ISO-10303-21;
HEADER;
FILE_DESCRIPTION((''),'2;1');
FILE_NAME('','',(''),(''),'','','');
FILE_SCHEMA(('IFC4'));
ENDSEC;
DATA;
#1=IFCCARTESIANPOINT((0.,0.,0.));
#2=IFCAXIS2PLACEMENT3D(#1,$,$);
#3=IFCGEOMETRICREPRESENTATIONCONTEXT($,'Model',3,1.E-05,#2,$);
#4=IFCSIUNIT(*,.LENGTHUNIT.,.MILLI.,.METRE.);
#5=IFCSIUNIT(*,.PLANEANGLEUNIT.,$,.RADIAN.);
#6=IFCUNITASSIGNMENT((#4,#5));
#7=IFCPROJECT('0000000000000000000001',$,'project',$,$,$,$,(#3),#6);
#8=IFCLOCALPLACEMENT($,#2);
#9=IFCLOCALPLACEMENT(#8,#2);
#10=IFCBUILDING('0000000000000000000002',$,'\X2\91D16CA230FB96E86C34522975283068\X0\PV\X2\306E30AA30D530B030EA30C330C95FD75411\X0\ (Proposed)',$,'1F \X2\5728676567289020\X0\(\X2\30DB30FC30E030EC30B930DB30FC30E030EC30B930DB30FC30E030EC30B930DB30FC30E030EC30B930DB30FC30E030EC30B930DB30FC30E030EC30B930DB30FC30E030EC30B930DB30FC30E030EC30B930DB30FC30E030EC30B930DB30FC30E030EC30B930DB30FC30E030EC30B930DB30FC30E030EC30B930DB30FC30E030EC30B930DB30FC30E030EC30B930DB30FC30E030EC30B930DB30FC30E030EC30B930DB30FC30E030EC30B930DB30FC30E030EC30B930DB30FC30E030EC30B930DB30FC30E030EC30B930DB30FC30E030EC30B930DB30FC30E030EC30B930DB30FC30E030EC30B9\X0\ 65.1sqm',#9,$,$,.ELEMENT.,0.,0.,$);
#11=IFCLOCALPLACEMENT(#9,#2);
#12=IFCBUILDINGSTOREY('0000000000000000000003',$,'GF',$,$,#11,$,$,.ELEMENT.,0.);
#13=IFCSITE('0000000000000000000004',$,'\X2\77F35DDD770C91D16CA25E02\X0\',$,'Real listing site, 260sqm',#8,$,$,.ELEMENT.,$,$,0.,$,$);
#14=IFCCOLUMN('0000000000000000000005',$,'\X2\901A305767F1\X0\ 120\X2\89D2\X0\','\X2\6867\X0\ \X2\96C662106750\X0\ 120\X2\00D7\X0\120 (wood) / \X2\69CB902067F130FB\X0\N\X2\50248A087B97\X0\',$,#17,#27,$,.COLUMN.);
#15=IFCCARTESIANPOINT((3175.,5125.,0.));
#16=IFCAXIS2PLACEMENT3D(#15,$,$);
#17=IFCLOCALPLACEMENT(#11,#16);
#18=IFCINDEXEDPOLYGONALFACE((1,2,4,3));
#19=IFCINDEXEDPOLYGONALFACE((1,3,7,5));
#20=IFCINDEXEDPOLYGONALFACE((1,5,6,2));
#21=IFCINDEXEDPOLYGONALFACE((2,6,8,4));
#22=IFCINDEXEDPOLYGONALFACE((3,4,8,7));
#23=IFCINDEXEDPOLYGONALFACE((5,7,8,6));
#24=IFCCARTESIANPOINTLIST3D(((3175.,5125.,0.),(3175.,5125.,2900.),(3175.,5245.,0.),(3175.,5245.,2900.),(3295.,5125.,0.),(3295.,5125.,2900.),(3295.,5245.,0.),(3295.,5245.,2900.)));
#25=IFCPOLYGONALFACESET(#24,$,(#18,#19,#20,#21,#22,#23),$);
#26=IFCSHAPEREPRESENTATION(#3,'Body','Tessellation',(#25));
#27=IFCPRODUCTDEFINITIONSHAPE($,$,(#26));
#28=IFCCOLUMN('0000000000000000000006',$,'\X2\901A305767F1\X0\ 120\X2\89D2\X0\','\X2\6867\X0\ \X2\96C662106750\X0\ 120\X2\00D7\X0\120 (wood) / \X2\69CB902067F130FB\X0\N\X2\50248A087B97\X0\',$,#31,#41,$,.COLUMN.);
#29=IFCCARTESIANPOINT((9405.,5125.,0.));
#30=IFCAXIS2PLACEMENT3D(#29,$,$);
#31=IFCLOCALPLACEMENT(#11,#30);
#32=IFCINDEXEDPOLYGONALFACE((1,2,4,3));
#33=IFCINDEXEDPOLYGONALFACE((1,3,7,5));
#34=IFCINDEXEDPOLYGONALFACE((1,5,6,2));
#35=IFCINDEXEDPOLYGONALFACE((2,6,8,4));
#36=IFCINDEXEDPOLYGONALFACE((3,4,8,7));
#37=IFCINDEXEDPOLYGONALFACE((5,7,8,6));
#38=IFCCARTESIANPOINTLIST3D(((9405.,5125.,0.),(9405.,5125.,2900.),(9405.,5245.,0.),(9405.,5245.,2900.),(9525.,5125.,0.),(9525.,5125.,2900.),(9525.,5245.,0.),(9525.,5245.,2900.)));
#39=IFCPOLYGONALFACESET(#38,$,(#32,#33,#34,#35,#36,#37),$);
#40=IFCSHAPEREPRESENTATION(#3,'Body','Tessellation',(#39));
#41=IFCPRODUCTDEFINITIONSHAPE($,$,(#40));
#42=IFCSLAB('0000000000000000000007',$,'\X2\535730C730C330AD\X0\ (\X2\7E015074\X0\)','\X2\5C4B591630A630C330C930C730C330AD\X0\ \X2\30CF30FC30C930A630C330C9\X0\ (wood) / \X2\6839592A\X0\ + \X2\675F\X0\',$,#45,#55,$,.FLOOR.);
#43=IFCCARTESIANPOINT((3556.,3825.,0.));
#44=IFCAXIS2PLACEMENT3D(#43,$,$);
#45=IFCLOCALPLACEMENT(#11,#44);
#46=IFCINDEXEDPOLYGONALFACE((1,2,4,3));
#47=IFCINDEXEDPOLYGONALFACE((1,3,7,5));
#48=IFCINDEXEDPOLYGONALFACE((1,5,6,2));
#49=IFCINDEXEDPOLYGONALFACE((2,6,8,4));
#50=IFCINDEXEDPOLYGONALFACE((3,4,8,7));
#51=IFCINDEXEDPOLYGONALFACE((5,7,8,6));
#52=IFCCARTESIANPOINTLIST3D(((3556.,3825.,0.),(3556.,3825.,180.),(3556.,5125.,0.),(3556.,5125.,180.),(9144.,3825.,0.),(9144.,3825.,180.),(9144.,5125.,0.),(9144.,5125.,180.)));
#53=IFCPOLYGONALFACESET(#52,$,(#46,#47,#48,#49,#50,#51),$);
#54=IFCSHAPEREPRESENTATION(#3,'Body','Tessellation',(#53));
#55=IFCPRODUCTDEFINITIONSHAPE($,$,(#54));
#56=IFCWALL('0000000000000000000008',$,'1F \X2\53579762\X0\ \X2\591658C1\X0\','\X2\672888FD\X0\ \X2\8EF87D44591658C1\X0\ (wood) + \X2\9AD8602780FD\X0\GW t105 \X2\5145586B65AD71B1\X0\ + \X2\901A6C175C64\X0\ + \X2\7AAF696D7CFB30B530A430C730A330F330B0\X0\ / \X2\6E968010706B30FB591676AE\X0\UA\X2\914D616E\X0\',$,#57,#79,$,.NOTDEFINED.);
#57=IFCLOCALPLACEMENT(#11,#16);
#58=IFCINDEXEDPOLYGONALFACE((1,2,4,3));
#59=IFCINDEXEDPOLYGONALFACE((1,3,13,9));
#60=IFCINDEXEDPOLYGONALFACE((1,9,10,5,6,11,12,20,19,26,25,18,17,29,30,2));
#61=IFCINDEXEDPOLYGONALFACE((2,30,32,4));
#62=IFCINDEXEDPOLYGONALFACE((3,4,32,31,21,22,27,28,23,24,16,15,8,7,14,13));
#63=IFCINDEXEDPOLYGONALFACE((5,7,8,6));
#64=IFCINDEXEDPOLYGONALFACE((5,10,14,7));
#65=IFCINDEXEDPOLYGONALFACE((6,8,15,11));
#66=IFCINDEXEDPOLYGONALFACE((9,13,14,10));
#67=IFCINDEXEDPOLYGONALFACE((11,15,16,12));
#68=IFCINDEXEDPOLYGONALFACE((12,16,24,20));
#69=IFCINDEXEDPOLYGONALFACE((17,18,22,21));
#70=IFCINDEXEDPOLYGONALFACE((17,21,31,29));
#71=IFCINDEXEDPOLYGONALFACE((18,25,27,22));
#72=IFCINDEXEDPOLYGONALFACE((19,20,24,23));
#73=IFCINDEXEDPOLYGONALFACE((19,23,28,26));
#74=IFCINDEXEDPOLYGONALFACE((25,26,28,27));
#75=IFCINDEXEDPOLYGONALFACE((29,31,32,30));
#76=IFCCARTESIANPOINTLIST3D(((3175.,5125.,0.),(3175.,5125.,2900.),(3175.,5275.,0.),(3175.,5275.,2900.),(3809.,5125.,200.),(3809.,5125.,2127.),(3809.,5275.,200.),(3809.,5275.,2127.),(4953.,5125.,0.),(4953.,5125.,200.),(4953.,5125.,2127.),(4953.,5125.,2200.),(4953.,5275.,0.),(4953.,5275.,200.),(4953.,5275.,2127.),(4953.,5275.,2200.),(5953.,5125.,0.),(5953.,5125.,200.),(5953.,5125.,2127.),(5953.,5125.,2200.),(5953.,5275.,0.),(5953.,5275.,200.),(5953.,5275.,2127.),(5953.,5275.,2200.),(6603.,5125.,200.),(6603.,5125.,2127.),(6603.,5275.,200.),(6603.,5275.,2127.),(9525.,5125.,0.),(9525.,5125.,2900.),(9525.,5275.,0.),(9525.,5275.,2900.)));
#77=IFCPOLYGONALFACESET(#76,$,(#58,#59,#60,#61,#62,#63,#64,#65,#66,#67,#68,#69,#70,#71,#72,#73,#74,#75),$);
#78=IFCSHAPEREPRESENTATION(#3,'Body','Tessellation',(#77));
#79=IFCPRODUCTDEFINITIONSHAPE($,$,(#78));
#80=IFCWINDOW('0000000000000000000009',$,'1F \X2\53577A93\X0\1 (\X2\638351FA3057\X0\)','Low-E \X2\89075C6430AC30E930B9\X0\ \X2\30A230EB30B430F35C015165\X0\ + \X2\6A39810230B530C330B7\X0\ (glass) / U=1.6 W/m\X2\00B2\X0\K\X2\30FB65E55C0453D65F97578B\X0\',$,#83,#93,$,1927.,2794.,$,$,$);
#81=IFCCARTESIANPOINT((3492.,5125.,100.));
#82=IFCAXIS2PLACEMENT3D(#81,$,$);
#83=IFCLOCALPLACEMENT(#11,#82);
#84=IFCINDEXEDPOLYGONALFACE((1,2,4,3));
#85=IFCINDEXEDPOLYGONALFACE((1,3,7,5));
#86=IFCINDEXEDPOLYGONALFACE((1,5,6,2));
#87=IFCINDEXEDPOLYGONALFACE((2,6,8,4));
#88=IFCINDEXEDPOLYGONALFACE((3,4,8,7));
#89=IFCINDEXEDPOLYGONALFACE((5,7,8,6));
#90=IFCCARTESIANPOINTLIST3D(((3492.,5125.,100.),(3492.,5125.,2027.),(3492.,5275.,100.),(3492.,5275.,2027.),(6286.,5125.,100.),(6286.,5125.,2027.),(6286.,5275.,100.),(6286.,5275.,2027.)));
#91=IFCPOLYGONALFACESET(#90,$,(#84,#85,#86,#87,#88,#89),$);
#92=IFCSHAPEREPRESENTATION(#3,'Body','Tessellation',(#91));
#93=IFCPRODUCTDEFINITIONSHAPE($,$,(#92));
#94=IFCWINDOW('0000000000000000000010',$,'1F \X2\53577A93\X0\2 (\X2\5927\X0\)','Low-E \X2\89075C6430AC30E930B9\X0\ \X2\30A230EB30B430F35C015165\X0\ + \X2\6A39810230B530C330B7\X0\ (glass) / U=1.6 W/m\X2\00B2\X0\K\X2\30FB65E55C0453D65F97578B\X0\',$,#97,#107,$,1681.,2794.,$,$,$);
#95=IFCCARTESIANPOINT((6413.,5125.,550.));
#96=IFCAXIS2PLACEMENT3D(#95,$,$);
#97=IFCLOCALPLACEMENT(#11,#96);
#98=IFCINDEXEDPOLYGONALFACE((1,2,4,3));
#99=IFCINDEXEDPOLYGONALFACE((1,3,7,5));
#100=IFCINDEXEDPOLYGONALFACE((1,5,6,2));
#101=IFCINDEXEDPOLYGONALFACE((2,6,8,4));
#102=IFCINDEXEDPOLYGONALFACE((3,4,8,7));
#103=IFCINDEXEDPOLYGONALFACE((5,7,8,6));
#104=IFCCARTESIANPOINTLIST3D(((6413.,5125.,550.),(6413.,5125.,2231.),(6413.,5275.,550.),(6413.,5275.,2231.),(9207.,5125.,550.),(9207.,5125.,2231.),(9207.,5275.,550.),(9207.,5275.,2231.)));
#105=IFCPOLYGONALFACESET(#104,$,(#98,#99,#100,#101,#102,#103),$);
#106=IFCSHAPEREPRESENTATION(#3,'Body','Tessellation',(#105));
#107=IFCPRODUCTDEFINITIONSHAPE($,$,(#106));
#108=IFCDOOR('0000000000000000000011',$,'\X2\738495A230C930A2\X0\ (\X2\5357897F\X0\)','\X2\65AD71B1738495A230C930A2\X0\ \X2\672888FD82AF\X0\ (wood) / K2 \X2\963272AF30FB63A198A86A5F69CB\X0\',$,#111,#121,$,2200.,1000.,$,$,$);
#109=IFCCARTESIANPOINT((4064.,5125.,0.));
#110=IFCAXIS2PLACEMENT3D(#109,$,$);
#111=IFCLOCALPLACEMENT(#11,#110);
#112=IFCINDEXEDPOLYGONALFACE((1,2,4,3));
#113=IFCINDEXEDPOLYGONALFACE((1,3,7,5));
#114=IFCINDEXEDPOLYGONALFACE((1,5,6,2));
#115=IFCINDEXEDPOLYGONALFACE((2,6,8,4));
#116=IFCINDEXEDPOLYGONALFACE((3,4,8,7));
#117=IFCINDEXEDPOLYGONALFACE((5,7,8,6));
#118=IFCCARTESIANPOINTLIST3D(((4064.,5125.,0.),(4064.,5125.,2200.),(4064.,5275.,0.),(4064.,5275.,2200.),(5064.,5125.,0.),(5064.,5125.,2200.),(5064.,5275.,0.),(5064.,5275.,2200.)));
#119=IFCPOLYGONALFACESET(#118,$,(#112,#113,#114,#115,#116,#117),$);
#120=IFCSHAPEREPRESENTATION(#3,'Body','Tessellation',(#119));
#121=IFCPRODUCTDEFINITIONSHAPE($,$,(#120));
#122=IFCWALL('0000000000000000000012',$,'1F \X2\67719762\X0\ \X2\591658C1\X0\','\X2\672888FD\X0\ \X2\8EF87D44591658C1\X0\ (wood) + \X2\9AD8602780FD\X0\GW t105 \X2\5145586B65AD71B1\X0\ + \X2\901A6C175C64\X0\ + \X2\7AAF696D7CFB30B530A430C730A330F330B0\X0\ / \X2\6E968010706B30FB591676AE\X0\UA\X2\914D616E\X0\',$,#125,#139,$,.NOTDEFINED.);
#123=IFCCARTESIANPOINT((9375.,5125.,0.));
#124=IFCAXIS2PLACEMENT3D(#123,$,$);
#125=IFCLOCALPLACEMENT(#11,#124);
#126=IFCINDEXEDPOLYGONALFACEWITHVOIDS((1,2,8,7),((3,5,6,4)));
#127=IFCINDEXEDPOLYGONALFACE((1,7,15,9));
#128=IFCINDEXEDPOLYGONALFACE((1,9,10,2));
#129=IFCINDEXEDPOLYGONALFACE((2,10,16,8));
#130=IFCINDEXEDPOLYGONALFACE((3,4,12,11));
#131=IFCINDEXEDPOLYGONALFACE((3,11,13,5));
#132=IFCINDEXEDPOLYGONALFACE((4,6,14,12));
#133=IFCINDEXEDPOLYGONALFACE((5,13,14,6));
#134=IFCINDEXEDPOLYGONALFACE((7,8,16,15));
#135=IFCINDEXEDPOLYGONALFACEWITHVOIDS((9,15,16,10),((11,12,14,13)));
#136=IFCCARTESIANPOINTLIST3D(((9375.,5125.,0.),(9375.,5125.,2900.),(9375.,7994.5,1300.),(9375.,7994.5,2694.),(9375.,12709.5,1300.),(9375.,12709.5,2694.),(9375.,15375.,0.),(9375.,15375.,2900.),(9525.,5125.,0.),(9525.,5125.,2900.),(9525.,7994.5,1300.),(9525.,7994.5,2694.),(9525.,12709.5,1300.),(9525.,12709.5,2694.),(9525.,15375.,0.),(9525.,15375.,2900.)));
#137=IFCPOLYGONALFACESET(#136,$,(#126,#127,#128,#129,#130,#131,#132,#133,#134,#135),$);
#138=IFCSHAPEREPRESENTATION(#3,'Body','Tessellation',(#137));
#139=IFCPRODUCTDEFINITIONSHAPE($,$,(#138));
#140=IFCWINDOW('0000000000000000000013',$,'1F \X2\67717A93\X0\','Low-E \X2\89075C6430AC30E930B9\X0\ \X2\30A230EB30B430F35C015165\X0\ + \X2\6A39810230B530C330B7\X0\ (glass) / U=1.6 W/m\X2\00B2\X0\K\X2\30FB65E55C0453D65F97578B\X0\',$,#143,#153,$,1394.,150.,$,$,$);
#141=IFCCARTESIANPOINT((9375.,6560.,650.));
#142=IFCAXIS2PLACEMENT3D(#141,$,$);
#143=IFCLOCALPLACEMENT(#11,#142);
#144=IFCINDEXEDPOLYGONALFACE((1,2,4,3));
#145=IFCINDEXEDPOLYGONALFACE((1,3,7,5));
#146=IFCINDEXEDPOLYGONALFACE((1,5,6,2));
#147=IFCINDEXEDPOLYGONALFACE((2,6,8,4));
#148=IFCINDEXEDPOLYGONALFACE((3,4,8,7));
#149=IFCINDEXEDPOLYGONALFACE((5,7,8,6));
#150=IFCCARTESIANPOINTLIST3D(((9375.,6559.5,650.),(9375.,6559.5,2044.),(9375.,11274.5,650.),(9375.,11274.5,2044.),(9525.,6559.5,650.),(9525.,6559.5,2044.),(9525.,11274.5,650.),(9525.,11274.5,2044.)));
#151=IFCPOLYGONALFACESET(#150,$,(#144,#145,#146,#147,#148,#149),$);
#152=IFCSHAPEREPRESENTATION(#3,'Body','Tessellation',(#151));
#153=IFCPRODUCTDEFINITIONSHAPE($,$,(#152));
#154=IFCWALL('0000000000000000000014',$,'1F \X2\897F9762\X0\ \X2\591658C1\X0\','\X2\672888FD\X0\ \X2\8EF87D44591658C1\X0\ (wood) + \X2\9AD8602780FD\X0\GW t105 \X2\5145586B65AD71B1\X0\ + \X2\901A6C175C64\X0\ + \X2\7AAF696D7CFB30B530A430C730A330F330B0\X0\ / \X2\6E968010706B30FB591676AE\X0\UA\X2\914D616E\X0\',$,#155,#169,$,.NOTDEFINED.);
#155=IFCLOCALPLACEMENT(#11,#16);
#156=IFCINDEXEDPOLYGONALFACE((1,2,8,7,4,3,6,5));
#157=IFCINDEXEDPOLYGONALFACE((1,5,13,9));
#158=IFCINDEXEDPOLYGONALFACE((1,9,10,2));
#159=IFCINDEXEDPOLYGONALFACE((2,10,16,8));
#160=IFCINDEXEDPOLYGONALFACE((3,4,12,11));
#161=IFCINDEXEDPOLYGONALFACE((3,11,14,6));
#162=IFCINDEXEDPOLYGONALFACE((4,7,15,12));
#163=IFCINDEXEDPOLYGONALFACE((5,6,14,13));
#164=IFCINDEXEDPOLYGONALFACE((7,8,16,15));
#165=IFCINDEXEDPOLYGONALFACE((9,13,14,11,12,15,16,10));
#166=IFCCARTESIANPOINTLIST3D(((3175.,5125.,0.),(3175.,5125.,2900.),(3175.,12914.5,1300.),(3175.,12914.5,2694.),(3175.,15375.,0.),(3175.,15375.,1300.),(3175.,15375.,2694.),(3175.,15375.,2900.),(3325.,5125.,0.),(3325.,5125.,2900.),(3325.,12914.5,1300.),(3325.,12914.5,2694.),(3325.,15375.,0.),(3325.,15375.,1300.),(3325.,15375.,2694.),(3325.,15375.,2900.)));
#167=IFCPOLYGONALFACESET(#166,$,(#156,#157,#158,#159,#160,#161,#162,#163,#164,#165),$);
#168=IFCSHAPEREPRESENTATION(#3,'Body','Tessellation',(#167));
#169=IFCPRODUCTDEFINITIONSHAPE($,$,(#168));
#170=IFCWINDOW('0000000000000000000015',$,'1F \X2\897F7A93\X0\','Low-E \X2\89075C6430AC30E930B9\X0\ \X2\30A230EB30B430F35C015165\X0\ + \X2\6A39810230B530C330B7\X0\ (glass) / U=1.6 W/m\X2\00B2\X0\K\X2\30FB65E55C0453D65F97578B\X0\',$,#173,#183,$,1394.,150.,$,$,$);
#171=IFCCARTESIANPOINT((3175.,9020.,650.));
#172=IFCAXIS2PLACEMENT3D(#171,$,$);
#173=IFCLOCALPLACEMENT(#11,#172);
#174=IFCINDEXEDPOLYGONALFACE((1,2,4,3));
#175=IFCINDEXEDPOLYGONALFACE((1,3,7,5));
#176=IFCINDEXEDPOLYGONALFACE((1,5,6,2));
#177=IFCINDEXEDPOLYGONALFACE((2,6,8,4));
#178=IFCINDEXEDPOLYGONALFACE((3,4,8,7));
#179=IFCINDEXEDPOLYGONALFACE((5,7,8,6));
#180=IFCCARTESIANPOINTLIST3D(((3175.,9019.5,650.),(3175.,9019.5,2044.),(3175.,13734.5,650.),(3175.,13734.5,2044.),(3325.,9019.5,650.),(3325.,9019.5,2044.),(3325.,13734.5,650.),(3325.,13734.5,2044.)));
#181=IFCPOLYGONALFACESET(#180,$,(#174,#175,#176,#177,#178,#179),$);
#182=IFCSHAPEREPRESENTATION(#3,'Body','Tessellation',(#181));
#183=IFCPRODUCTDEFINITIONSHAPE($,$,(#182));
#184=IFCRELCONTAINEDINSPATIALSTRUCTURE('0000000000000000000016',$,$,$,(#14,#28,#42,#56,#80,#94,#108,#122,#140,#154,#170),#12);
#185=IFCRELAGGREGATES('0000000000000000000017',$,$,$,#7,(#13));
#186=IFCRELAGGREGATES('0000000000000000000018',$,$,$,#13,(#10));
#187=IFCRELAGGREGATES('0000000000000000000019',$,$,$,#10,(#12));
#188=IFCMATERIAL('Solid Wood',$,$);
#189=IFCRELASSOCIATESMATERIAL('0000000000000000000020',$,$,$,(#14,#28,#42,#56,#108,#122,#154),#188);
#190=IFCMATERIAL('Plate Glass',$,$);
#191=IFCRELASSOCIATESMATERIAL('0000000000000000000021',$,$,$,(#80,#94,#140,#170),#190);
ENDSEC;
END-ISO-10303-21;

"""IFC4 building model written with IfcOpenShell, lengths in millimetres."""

from ifc_helpers import new_model, si_unit, frame, frame_2d, origin, place, context, project, spatial, rectangle, extrude, material, element, fill, save


model = new_model("IFC4")

# Units and contexts
model_context = context("Model", 3, precision=1e-05, world=origin())
ifc_project = project(units=[si_unit("LENGTHUNIT", "METRE", prefix="MILLI"), si_unit("PLANEANGLEUNIT", "RADIAN")], contexts=[model_context])

# Site, building, storey
site_placement = place(None, origin())
site = spatial("IfcSite", under=ifc_project, at=site_placement, Name="石川県金沢市", ObjectType="Real listing site, 260sqm", CompositionType="ELEMENT", RefElevation=0.0)
building_placement = place(site_placement, origin())
building = spatial("IfcBuilding", under=site, at=building_placement, Name="金沢・雨水利用とPVのオフグリッド志向 (Proposed)", ObjectType="1F 在来木造(ホームレスホームレスホームレスホームレスホームレスホームレスホームレスホームレスホームレスホームレスホームレスホームレスホームレスホームレスホームレスホームレスホームレスホームレスホームレスホームレスホームレスホームレスホームレス 65.1sqm", CompositionType="ELEMENT", ElevationOfRefHeight=0.0, ElevationOfTerrain=0.0)
storey_placement = place(building_placement, origin())
storey = spatial("IfcBuildingStorey", under=building, at=storey_placement, Name="GF", CompositionType="ELEMENT", Elevation=0.0)

# Columns
ifc_material_1 = material(Name="Solid Wood")
column_1_placement = place(storey_placement, frame((3175.0, 5125.0, 0.0)))
element("IfcColumn", 1, at=column_1_placement, inside=storey, material=ifc_material_1, Name="通し柱 120角", Description="桧 集成材 120×120 (wood) / 構造柱・N値計算", PredefinedType="COLUMN", context=model_context, shape_type="SweptSolid", body=[
    extrude(rectangle(XDim=120.0, YDim=120.0, at=frame_2d((60.0, 60.0))), frame((3175.0, 5125.0, 0.0)), (0.0, 0.0, 1.0), 2900.0),
])
column_2_placement = place(storey_placement, frame((9405.0, 5125.0, 0.0)))
element("IfcColumn", 2, at=column_2_placement, inside=storey, material=ifc_material_1, Name="通し柱 120角", Description="桧 集成材 120×120 (wood) / 構造柱・N値計算", PredefinedType="COLUMN", context=model_context, shape_type="SweptSolid", body=[
    extrude(rectangle(XDim=120.0, YDim=120.0, at=frame_2d((60.0, 60.0))), frame((9405.0, 5125.0, 0.0)), (0.0, 0.0, 1.0), 2900.0),
])

# Slab
slab_1_placement = place(storey_placement, frame((3556.0, 3825.0, 0.0)))
element("IfcSlab", 3, at=slab_1_placement, inside=storey, material=ifc_material_1, Name="南デッキ (縁側)", Description="屋外ウッドデッキ ハードウッド (wood) / 根太 + 束", PredefinedType="FLOOR", context=model_context, shape_type="SweptSolid", body=[
    extrude(rectangle(XDim=5588.0, YDim=1300.0, at=frame_2d((2794.0, 650.0))), frame((3556.0, 3825.0, 0.0)), (0.0, 0.0, 1.0), 180.0),
])

# Wall, openings, windows, door
wall_1_placement = place(storey_placement, frame((3175.0, 5125.0, 0.0)))
wall_1 = element("IfcWall", 4, at=wall_1_placement, inside=storey, material=ifc_material_1, Name="1F 南面 外壁", Description="木製 軸組外壁 (wood) + 高性能GW t105 充填断熱 + 通気層 + 窯業系サイディング / 準耐火・外皮UA配慮", PredefinedType="NOTDEFINED", context=model_context, shape_type="SweptSolid", body=[
    extrude(rectangle(XDim=6350.0, YDim=150.0, at=frame_2d((3175.0, 75.0))), frame((3175.0, 5125.0, 0.0)), (0.0, 0.0, 1.0), 2900.0),
])
opening_1_placement = place(storey_placement, frame((3492.0, 5125.0, 100.0)))
opening_1 = element("IfcOpeningElement", 5, at=opening_1_placement, cuts=wall_1, PredefinedType="NOTDEFINED", context=model_context, shape_type="SweptSolid", body=[
    extrude(rectangle(XDim=2794.0, YDim=150.0, at=frame_2d((1397.0, 75.0))), frame((3492.0, 5125.0, 100.0)), (0.0, 0.0, 1.0), 1927.0),
])
opening_2_placement = place(storey_placement, frame((6413.0, 5125.0, 550.0)))
opening_2 = element("IfcOpeningElement", 6, at=opening_2_placement, cuts=wall_1, PredefinedType="NOTDEFINED", context=model_context, shape_type="SweptSolid", body=[
    extrude(rectangle(XDim=2794.0, YDim=150.0, at=frame_2d((1397.0, 75.0))), frame((6413.0, 5125.0, 550.0)), (0.0, 0.0, 1.0), 1681.0),
])
opening_3_placement = place(storey_placement, frame((4064.0, 5125.0, 0.0)))
opening_3 = element("IfcOpeningElement", 7, at=opening_3_placement, cuts=wall_1, PredefinedType="NOTDEFINED", context=model_context, shape_type="SweptSolid", body=[
    extrude(rectangle(XDim=1000.0, YDim=150.0, at=frame_2d((500.0, 75.0))), frame((4064.0, 5125.0, 0.0)), (0.0, 0.0, 1.0), 2200.0),
])
ifc_material_2 = material(Name="Plate Glass")
window_1_placement = place(storey_placement, frame((3492.0, 5125.0, 100.0)))
window_1 = element("IfcWindow", 8, at=window_1_placement, inside=storey, material=ifc_material_2, Name="1F 南窓1 (掃出し)", Description="Low-E 複層ガラス アルゴン封入 + 樹脂サッシ (glass) / U=1.6 W/m²K・日射取得型", OverallHeight=1927.0, OverallWidth=2794.0, context=model_context, shape_type="SweptSolid", body=[
    extrude(rectangle(XDim=2794.0, YDim=150.0, at=frame_2d((1397.0, 75.0))), frame((3492.0, 5125.0, 100.0)), (0.0, 0.0, 1.0), 1927.0),
])
fill(opening_1, window_1)
window_2_placement = place(storey_placement, frame((6413.0, 5125.0, 550.0)))
window_2 = element("IfcWindow", 9, at=window_2_placement, inside=storey, material=ifc_material_2, Name="1F 南窓2 (大)", Description="Low-E 複層ガラス アルゴン封入 + 樹脂サッシ (glass) / U=1.6 W/m²K・日射取得型", OverallHeight=1681.0, OverallWidth=2794.0, context=model_context, shape_type="SweptSolid", body=[
    extrude(rectangle(XDim=2794.0, YDim=150.0, at=frame_2d((1397.0, 75.0))), frame((6413.0, 5125.0, 550.0)), (0.0, 0.0, 1.0), 1681.0),
])
fill(opening_2, window_2)
door_placement = place(storey_placement, frame((4064.0, 5125.0, 0.0)))
door = element("IfcDoor", 10, at=door_placement, inside=storey, material=ifc_material_1, Name="玄関ドア (南西)", Description="断熱玄関ドア 木製芯 (wood) / K2 防犯・採風機構", OverallHeight=2200.0, OverallWidth=1000.0, context=model_context, shape_type="SweptSolid", body=[
    extrude(rectangle(XDim=1000.0, YDim=150.0, at=frame_2d((500.0, 75.0))), frame((4064.0, 5125.0, 0.0)), (0.0, 0.0, 1.0), 2200.0),
])
fill(opening_3, door)

# Walls, openings, windows
wall_2_placement = place(storey_placement, frame((9375.0, 5125.0, 0.0)))
wall_2 = element("IfcWall", 11, at=wall_2_placement, inside=storey, material=ifc_material_1, Name="1F 東面 外壁", Description="木製 軸組外壁 (wood) + 高性能GW t105 充填断熱 + 通気層 + 窯業系サイディング / 準耐火・外皮UA配慮", PredefinedType="NOTDEFINED", context=model_context, shape_type="SweptSolid", body=[
    extrude(rectangle(XDim=150.0, YDim=10250.0, at=frame_2d((75.0, 5125.0))), frame((9375.0, 5125.0, 0.0)), (0.0, 0.0, 1.0), 2900.0),
])
opening_4_placement = place(storey_placement, frame((9375.0, 6560.0, 650.0)))
opening_4 = element("IfcOpeningElement", 12, at=opening_4_placement, cuts=wall_2, PredefinedType="NOTDEFINED", context=model_context, shape_type="SweptSolid", body=[
    extrude(rectangle(XDim=150.0, YDim=4715.0, at=frame_2d((75.0, 2357.0))), frame((9375.0, 6560.0, 650.0)), (0.0, 0.0, 1.0), 1394.0),
])
window_3_placement = place(storey_placement, frame((9375.0, 6560.0, 650.0)))
window_3 = element("IfcWindow", 13, at=window_3_placement, inside=storey, material=ifc_material_2, Name="1F 東窓", Description="Low-E 複層ガラス アルゴン封入 + 樹脂サッシ (glass) / U=1.6 W/m²K・日射取得型", OverallHeight=1394.0, OverallWidth=150.0, context=model_context, shape_type="SweptSolid", body=[
    extrude(rectangle(XDim=150.0, YDim=4715.0, at=frame_2d((75.0, 2357.0))), frame((9375.0, 6560.0, 650.0)), (0.0, 0.0, 1.0), 1394.0),
])
fill(opening_4, window_3)
wall_3_placement = place(storey_placement, frame((3175.0, 5125.0, 0.0)))
wall_3 = element("IfcWall", 14, at=wall_3_placement, inside=storey, material=ifc_material_1, Name="1F 西面 外壁", Description="木製 軸組外壁 (wood) + 高性能GW t105 充填断熱 + 通気層 + 窯業系サイディング / 準耐火・外皮UA配慮", PredefinedType="NOTDEFINED", context=model_context, shape_type="SweptSolid", body=[
    extrude(rectangle(XDim=150.0, YDim=10250.0, at=frame_2d((75.0, 5125.0))), frame((3175.0, 5125.0, 0.0)), (0.0, 0.0, 1.0), 2900.0),
])
opening_5_placement = place(storey_placement, frame((3175.0, 9020.0, 650.0)))
opening_5 = element("IfcOpeningElement", 15, at=opening_5_placement, cuts=wall_3, PredefinedType="NOTDEFINED", context=model_context, shape_type="SweptSolid", body=[
    extrude(rectangle(XDim=150.0, YDim=4715.0, at=frame_2d((75.0, 2357.0))), frame((3175.0, 9020.0, 650.0)), (0.0, 0.0, 1.0), 1394.0),
])
window_4_placement = place(storey_placement, frame((3175.0, 9020.0, 650.0)))
window_4 = element("IfcWindow", 16, at=window_4_placement, inside=storey, material=ifc_material_2, Name="1F 西窓", Description="Low-E 複層ガラス アルゴン封入 + 樹脂サッシ (glass) / U=1.6 W/m²K・日射取得型", OverallHeight=1394.0, OverallWidth=150.0, context=model_context, shape_type="SweptSolid", body=[
    extrude(rectangle(XDim=150.0, YDim=4715.0, at=frame_2d((75.0, 2357.0))), frame((3175.0, 9020.0, 650.0)), (0.0, 0.0, 1.0), 1394.0),
])
fill(opening_5, window_4)

save(model, "model.ifc")
